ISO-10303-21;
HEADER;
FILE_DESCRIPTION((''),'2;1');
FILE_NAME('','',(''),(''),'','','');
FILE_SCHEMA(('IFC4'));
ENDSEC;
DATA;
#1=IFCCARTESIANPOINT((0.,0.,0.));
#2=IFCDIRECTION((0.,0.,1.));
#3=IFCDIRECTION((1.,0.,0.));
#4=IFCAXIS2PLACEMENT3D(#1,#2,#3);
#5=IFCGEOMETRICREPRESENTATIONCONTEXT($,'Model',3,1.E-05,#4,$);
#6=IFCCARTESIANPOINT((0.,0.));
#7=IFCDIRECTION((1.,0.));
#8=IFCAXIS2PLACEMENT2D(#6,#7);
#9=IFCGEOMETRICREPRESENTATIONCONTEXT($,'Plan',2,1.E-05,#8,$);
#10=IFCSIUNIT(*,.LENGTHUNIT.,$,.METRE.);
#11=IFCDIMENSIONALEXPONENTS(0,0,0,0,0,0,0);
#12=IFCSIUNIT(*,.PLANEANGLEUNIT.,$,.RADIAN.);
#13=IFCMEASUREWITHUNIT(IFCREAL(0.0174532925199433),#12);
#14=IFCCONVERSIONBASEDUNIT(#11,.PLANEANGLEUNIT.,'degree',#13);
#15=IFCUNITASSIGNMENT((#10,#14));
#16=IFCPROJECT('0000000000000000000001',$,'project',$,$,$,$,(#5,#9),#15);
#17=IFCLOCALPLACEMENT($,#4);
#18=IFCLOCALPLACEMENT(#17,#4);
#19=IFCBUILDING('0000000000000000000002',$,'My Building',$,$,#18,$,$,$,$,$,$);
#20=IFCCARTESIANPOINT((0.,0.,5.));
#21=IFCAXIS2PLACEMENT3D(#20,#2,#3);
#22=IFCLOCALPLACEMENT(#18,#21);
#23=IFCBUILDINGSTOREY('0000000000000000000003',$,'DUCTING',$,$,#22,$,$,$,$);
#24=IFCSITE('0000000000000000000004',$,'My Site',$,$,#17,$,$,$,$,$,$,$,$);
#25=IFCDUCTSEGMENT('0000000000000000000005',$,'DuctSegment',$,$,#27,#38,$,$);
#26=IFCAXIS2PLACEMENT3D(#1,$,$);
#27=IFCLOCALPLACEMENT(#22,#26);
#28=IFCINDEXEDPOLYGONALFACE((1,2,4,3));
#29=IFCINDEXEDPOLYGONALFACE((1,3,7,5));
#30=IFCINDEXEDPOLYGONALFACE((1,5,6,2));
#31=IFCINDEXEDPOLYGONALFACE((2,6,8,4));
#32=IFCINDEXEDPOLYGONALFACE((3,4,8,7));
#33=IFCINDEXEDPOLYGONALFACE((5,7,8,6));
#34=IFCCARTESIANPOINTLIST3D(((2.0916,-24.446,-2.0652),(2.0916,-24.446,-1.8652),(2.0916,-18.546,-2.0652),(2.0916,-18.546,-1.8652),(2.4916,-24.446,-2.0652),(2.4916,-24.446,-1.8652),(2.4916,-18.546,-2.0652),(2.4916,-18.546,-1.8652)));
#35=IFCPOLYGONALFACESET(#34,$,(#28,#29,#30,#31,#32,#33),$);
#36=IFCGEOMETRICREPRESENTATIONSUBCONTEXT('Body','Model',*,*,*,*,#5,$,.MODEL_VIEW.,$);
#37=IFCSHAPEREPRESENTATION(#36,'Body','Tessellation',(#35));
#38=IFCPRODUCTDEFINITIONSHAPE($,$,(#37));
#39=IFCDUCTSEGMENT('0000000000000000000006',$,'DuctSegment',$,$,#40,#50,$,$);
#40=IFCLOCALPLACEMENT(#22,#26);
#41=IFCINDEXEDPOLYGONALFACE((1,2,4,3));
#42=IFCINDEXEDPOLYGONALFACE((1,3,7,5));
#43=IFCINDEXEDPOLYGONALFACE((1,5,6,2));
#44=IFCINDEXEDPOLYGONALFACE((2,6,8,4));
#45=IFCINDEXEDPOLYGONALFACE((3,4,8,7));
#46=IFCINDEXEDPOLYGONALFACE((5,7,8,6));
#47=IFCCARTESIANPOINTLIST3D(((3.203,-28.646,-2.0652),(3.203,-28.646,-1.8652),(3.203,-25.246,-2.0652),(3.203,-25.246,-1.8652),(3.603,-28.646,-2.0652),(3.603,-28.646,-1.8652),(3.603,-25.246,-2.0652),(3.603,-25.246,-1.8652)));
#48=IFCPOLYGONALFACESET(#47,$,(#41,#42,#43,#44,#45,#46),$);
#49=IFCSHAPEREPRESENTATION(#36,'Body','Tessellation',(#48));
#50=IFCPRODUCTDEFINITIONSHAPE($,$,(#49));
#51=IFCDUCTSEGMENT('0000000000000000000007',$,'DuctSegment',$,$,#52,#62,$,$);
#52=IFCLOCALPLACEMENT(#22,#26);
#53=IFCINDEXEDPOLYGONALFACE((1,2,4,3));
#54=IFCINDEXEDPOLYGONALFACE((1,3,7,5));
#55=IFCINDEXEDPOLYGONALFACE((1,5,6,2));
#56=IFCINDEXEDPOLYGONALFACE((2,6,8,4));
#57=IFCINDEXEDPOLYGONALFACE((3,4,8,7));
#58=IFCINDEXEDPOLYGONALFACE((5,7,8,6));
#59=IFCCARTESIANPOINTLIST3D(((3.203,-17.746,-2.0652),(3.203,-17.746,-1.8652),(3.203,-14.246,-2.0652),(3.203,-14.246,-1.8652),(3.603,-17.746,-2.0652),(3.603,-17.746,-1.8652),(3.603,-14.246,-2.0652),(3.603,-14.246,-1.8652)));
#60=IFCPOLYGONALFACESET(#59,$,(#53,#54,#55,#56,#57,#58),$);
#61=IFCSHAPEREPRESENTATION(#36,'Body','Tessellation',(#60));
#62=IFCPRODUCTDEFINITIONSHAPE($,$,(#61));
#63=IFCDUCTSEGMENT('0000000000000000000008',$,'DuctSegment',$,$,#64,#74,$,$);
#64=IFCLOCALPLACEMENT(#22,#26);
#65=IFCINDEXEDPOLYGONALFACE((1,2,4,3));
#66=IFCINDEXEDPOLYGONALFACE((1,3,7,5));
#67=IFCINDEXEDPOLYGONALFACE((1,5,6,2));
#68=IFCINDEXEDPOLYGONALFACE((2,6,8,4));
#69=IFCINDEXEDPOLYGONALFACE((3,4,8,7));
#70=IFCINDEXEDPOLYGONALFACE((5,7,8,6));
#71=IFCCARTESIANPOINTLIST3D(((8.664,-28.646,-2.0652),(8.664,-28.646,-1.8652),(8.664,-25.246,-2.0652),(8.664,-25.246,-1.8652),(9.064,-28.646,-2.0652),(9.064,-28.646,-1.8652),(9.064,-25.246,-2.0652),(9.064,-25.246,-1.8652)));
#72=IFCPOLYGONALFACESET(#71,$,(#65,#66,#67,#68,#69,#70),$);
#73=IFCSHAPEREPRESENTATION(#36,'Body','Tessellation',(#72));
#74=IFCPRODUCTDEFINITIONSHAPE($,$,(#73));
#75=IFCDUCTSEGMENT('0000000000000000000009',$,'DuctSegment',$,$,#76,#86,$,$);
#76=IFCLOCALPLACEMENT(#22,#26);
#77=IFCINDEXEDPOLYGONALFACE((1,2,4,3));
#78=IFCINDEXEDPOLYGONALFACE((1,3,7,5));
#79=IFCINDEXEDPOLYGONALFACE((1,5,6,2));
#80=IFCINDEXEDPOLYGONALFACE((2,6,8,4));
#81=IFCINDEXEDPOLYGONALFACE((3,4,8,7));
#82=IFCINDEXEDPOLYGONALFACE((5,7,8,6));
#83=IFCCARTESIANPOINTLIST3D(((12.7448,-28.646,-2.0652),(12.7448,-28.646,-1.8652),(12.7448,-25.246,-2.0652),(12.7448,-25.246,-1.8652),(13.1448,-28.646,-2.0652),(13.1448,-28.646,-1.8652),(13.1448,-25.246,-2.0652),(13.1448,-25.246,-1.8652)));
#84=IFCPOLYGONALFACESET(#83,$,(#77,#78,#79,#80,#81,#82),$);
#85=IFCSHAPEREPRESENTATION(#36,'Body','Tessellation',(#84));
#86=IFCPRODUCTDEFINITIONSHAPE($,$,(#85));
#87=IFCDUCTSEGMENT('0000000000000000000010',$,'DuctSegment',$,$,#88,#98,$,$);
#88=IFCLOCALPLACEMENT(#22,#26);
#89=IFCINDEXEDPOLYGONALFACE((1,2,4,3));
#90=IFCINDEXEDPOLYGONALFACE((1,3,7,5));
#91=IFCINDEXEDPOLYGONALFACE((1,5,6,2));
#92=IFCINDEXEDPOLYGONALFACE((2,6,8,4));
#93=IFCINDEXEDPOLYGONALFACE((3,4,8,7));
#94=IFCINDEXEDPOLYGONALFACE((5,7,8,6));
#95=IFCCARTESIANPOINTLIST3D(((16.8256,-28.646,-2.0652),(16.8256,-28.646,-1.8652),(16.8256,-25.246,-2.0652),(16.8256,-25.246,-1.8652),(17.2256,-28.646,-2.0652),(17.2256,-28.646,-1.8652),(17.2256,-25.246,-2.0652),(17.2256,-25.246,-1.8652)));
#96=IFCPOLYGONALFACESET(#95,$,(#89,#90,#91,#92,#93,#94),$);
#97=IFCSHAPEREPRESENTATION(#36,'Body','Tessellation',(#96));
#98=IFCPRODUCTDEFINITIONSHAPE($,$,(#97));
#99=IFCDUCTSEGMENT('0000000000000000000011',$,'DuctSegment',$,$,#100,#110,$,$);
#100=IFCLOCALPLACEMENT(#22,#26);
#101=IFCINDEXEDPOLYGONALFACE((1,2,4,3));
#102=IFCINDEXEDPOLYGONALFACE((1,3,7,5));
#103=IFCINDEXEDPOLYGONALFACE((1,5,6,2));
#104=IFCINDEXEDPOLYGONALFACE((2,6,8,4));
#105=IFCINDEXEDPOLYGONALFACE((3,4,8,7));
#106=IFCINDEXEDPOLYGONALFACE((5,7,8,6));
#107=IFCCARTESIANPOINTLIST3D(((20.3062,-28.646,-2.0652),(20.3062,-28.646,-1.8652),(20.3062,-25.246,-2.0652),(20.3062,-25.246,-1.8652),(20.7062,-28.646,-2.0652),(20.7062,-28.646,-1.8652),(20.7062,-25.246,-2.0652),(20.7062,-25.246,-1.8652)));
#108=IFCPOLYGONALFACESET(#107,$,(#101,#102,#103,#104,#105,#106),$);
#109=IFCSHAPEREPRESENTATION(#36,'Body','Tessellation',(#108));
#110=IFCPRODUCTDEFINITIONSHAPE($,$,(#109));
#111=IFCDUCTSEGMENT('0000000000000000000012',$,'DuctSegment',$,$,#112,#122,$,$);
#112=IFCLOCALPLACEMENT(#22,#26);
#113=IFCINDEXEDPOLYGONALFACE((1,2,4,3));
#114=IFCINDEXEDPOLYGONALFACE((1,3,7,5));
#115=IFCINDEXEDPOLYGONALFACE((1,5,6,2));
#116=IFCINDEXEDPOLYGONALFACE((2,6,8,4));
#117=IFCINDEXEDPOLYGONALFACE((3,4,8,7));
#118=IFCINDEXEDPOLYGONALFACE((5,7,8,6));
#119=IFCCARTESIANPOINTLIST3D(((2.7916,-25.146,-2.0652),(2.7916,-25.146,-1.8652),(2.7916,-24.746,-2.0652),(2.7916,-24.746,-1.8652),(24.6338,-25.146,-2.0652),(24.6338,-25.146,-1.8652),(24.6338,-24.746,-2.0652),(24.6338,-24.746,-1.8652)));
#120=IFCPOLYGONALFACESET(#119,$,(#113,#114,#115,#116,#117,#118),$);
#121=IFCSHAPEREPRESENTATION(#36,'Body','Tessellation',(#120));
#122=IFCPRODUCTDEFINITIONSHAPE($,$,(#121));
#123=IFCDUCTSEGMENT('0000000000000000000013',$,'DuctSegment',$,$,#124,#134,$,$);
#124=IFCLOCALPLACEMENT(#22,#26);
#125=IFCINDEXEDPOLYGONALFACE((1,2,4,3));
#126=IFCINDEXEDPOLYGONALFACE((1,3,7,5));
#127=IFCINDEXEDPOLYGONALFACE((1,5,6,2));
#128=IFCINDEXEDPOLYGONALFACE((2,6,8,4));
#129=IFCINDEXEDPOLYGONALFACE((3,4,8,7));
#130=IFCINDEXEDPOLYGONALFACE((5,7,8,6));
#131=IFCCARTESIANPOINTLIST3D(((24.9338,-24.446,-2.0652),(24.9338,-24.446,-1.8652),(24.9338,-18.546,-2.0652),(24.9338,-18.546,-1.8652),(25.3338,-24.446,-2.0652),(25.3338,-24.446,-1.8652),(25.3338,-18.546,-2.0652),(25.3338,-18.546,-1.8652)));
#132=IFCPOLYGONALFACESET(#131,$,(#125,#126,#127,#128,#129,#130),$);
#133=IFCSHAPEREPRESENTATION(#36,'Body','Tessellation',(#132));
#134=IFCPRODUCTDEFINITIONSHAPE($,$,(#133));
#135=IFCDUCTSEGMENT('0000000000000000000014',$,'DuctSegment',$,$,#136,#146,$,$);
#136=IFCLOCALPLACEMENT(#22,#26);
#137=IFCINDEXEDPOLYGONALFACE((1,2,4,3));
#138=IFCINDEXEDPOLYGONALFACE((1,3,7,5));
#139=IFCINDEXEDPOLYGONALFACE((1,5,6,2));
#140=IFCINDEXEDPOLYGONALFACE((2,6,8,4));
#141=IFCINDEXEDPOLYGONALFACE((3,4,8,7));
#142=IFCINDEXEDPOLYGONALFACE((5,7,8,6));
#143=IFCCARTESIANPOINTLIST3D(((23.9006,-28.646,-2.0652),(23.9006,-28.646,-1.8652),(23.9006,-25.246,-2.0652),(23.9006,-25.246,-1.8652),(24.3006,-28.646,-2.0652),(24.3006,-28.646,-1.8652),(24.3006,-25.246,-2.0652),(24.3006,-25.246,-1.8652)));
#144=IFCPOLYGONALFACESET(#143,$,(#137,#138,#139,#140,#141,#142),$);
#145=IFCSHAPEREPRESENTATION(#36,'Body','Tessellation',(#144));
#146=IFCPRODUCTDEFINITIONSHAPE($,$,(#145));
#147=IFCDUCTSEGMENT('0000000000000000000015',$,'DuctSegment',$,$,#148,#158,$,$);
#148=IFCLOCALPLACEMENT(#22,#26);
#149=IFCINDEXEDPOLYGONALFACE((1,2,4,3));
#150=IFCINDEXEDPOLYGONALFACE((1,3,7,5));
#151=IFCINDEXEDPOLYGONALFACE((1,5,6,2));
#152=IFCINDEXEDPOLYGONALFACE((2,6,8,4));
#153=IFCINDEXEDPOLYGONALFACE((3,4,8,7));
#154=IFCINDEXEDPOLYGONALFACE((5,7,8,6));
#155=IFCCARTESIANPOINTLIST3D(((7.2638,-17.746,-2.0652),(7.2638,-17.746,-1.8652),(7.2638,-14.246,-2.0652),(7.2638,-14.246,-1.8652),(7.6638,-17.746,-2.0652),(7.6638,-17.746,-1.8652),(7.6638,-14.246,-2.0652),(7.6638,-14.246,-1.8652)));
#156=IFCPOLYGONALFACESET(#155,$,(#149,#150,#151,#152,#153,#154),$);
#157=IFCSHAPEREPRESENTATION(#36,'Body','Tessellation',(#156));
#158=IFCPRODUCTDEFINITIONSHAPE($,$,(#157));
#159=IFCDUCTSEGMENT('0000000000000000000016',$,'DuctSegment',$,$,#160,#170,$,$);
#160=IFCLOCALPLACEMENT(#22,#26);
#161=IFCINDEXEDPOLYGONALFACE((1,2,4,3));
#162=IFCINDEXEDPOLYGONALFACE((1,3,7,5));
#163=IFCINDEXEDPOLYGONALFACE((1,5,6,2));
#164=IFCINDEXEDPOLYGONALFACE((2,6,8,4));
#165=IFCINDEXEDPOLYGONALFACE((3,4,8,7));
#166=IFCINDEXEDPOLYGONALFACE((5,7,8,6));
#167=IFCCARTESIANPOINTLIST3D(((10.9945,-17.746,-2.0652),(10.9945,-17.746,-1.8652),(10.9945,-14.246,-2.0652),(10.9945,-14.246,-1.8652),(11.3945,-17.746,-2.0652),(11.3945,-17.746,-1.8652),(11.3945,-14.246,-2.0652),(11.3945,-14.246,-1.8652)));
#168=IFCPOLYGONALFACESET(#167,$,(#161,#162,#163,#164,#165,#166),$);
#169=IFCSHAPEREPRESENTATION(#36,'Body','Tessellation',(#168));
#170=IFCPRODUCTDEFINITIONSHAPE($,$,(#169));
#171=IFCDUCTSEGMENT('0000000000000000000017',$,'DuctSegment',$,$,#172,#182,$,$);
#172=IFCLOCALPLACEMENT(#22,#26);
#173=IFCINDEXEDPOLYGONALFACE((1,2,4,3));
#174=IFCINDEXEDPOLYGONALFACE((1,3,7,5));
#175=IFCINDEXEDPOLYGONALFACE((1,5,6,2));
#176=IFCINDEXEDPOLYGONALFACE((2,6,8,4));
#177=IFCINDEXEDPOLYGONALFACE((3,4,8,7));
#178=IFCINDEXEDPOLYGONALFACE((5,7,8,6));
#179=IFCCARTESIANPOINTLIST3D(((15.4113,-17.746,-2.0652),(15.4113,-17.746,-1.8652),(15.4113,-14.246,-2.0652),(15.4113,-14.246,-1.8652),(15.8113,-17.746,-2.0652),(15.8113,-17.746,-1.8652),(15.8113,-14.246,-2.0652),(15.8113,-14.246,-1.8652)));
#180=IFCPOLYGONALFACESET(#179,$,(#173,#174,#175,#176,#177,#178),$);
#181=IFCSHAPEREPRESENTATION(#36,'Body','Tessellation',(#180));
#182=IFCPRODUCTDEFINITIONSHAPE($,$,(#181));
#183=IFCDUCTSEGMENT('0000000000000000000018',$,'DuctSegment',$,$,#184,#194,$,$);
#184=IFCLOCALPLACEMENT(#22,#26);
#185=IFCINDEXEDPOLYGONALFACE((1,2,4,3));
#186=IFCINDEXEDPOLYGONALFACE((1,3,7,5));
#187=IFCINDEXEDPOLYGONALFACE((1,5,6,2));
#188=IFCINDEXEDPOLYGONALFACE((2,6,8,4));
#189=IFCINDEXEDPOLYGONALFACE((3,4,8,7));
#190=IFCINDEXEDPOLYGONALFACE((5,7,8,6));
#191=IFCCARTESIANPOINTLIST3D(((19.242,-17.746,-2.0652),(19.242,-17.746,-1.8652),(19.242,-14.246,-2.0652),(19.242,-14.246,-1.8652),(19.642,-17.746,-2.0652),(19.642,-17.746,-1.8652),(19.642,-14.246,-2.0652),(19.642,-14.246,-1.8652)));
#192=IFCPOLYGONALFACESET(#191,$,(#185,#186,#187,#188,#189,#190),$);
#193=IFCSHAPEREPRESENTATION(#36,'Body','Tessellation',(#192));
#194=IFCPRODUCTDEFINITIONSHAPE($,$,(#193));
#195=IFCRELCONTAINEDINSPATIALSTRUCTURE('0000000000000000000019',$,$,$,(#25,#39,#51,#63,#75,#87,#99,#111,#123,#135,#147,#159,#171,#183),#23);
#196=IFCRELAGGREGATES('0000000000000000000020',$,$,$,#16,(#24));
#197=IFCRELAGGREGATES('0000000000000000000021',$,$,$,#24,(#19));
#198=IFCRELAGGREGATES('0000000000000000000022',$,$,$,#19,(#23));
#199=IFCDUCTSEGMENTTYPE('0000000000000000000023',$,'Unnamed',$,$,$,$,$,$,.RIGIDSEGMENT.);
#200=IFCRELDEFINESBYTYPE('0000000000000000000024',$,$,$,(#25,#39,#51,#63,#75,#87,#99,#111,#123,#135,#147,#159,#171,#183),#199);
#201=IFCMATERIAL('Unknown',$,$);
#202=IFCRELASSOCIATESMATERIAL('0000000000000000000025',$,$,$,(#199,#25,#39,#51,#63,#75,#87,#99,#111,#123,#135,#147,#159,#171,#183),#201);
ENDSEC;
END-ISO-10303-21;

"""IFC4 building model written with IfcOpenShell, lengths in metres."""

from ifc_helpers import new_model, entity, si_unit, converted_unit, frame, origin_with_axes, origin_2d_with_axis, place, context, subcontext, project, spatial, rectangle, extrude, material, material_profile, profile_set, profile_usage, type_object, element, save


model = new_model("IFC4")

# Units and contexts
model_context = context("Model", 3, precision=1e-05, world=origin_with_axes())
plan_context = context("Plan", 2, precision=1e-05, world=origin_2d_with_axis())
body_context = subcontext(model_context, "Body", "Model", "MODEL_VIEW")
ifc_project = project(units=[si_unit("LENGTHUNIT", "METRE"), converted_unit("PLANEANGLEUNIT", "degree", entity("IfcReal", 0.0174532925199433), si_unit("PLANEANGLEUNIT", "RADIAN"), dimensions=[0, 0, 0, 0, 0, 0, 0])], contexts=[model_context, plan_context])

# Site, building, storey
site_placement = place(None, origin_with_axes())
site = spatial("IfcSite", under=ifc_project, at=site_placement, Name="My Site")
building_placement = place(site_placement, origin_with_axes())
building = spatial("IfcBuilding", under=site, at=building_placement, Name="My Building")
storey_placement = place(building_placement, frame((0.0, 0.0, 5.0), z_axis=(0.0, 0.0, 1.0), x_axis=(1.0, 0.0, 0.0)))
storey = spatial("IfcBuildingStorey", under=building, at=storey_placement, Name="DUCTING")

# Duct segments
ifc_material = material(Name="Unknown")
ifc_material_profile = material_profile(ifc_material, rectangle(XDim=0.4, YDim=0.2))
ifc_profile_set = profile_set([ifc_material_profile])
ifc_profile_usage_1 = profile_usage(ifc_profile_set, cardinal=5)
duct_segment_type = type_object("IfcDuctSegmentType", Name="Unnamed", PredefinedType="RIGIDSEGMENT", material=ifc_profile_set)
duct_segment_1_placement = place(storey_placement, frame((2.2916, -18.546, -1.9652), z_axis=(0.0, -1.0, -0.000002), x_axis=(1.0, 0.0, 0.0)))
element("IfcDuctSegment", 1, at=duct_segment_1_placement, inside=storey, type_object=duct_segment_type, material=ifc_profile_usage_1, Name="DuctSegment", context=body_context, shape_type="SweptSolid", body=[
    extrude(rectangle(XDim=0.4, YDim=0.2), origin_with_axes(), (0.0, 0.0, 1.0), 5.9),
])
ifc_profile_usage_2 = profile_usage(ifc_profile_set, cardinal=5)
duct_segment_2_placement = place(storey_placement, frame((3.403, -25.246, -1.9652), z_axis=(0.0, -1.0, 0.000001), x_axis=(1.0, 0.0, 0.0)))
element("IfcDuctSegment", 2, at=duct_segment_2_placement, inside=storey, type_object=duct_segment_type, material=ifc_profile_usage_2, Name="DuctSegment", context=body_context, shape_type="SweptSolid", body=[
    extrude(rectangle(XDim=0.4, YDim=0.2), origin_with_axes(), (0.0, 0.0, 1.0), 3.4),
])
ifc_profile_usage_3 = profile_usage(ifc_profile_set, cardinal=5)
duct_segment_3_placement = place(storey_placement, frame((3.403, -14.246, -1.9652), z_axis=(0.0, -1.0, 0.000001), x_axis=(1.0, 0.0, 0.0)))
element("IfcDuctSegment", 3, at=duct_segment_3_placement, inside=storey, type_object=duct_segment_type, material=ifc_profile_usage_3, Name="DuctSegment", context=body_context, shape_type="SweptSolid", body=[
    extrude(rectangle(XDim=0.4, YDim=0.2), origin_with_axes(), (0.0, 0.0, 1.0), 3.5),
])
ifc_profile_usage_4 = profile_usage(ifc_profile_set, cardinal=5)
duct_segment_4_placement = place(storey_placement, frame((8.864, -25.246, -1.9652), z_axis=(0.0, -1.0, 0.000001), x_axis=(1.0, 0.0, 0.0)))
element("IfcDuctSegment", 4, at=duct_segment_4_placement, inside=storey, type_object=duct_segment_type, material=ifc_profile_usage_4, Name="DuctSegment", context=body_context, shape_type="SweptSolid", body=[
    extrude(rectangle(XDim=0.4, YDim=0.2), origin_with_axes(), (0.0, 0.0, 1.0), 3.4),
])
ifc_profile_usage_5 = profile_usage(ifc_profile_set, cardinal=5)
duct_segment_5_placement = place(storey_placement, frame((12.9448, -25.246, -1.9652), z_axis=(0.0, -1.0, 0.000001), x_axis=(1.0, 0.0, 0.0)))
element("IfcDuctSegment", 5, at=duct_segment_5_placement, inside=storey, type_object=duct_segment_type, material=ifc_profile_usage_5, Name="DuctSegment", context=body_context, shape_type="SweptSolid", body=[
    extrude(rectangle(XDim=0.4, YDim=0.2), origin_with_axes(), (0.0, 0.0, 1.0), 3.4),
])
ifc_profile_usage_6 = profile_usage(ifc_profile_set, cardinal=5)
duct_segment_6_placement = place(storey_placement, frame((17.0256, -25.246, -1.9652), z_axis=(0.0, -1.0, 0.000001), x_axis=(1.0, 0.0, 0.0)))
element("IfcDuctSegment", 6, at=duct_segment_6_placement, inside=storey, type_object=duct_segment_type, material=ifc_profile_usage_6, Name="DuctSegment", context=body_context, shape_type="SweptSolid", body=[
    extrude(rectangle(XDim=0.4, YDim=0.2), origin_with_axes(), (0.0, 0.0, 1.0), 3.4),
])
ifc_profile_usage_7 = profile_usage(ifc_profile_set, cardinal=5)
duct_segment_7_placement = place(storey_placement, frame((20.5062, -25.246, -1.9652), z_axis=(0.0, -1.0, 0.000001), x_axis=(1.0, 0.0, 0.0)))
element("IfcDuctSegment", 7, at=duct_segment_7_placement, inside=storey, type_object=duct_segment_type, material=ifc_profile_usage_7, Name="DuctSegment", context=body_context, shape_type="SweptSolid", body=[
    extrude(rectangle(XDim=0.4, YDim=0.2), origin_with_axes(), (0.0, 0.0, 1.0), 3.4),
])
ifc_profile_usage_8 = profile_usage(ifc_profile_set, cardinal=5)
duct_segment_8_placement = place(storey_placement, frame((2.7916, -24.946, -1.9652), z_axis=(1.0, 0.0, 0.000001), x_axis=(0.0, 1.0, 0.0)))
element("IfcDuctSegment", 8, at=duct_segment_8_placement, inside=storey, type_object=duct_segment_type, material=ifc_profile_usage_8, Name="DuctSegment", context=body_context, shape_type="SweptSolid", body=[
    extrude(rectangle(XDim=0.4, YDim=0.2), origin_with_axes(), (0.0, 0.0, 1.0), 21.8422),
])
ifc_profile_usage_9 = profile_usage(ifc_profile_set, cardinal=5)
duct_segment_9_placement = place(storey_placement, frame((25.1338, -18.546, -1.9652), z_axis=(0.0, -1.0, 0.0), x_axis=(1.0, 0.0, 0.0)))
element("IfcDuctSegment", 9, at=duct_segment_9_placement, inside=storey, type_object=duct_segment_type, material=ifc_profile_usage_9, Name="DuctSegment", context=body_context, shape_type="SweptSolid", body=[
    extrude(rectangle(XDim=0.4, YDim=0.2), origin_with_axes(), (0.0, 0.0, 1.0), 5.9),
])
ifc_profile_usage_10 = profile_usage(ifc_profile_set, cardinal=5)
duct_segment_10_placement = place(storey_placement, frame((24.1006, -25.246, -1.9652), z_axis=(0.0, -1.0, 0.000001), x_axis=(1.0, 0.0, 0.0)))
element("IfcDuctSegment", 10, at=duct_segment_10_placement, inside=storey, type_object=duct_segment_type, material=ifc_profile_usage_10, Name="DuctSegment", context=body_context, shape_type="SweptSolid", body=[
    extrude(rectangle(XDim=0.4, YDim=0.2), origin_with_axes(), (0.0, 0.0, 1.0), 3.4),
])
ifc_profile_usage_11 = profile_usage(ifc_profile_set, cardinal=5)
duct_segment_11_placement = place(storey_placement, frame((7.4638, -14.246, -1.9652), z_axis=(0.0, -1.0, 0.000001), x_axis=(1.0, 0.0, 0.0)))
element("IfcDuctSegment", 11, at=duct_segment_11_placement, inside=storey, type_object=duct_segment_type, material=ifc_profile_usage_11, Name="DuctSegment", context=body_context, shape_type="SweptSolid", body=[
    extrude(rectangle(XDim=0.4, YDim=0.2), origin_with_axes(), (0.0, 0.0, 1.0), 3.5),
])
ifc_profile_usage_12 = profile_usage(ifc_profile_set, cardinal=5)
duct_segment_12_placement = place(storey_placement, frame((11.1945, -14.246, -1.9652), z_axis=(0.0, -1.0, 0.000001), x_axis=(1.0, 0.0, 0.0)))
element("IfcDuctSegment", 12, at=duct_segment_12_placement, inside=storey, type_object=duct_segment_type, material=ifc_profile_usage_12, Name="DuctSegment", context=body_context, shape_type="SweptSolid", body=[
    extrude(rectangle(XDim=0.4, YDim=0.2), origin_with_axes(), (0.0, 0.0, 1.0), 3.5),
])
ifc_profile_usage_13 = profile_usage(ifc_profile_set, cardinal=5)
duct_segment_13_placement = place(storey_placement, frame((15.6113, -14.246, -1.9652), z_axis=(0.0, -1.0, 0.000001), x_axis=(1.0, 0.0, 0.0)))
element("IfcDuctSegment", 13, at=duct_segment_13_placement, inside=storey, type_object=duct_segment_type, material=ifc_profile_usage_13, Name="DuctSegment", context=body_context, shape_type="SweptSolid", body=[
    extrude(rectangle(XDim=0.4, YDim=0.2), origin_with_axes(), (0.0, 0.0, 1.0), 3.5),
])
ifc_profile_usage_14 = profile_usage(ifc_profile_set, cardinal=5)
duct_segment_14_placement = place(storey_placement, frame((19.442, -14.246, -1.9652), z_axis=(0.0, -1.0, 0.000001), x_axis=(1.0, 0.0, 0.0)))
element("IfcDuctSegment", 14, at=duct_segment_14_placement, inside=storey, type_object=duct_segment_type, material=ifc_profile_usage_14, Name="DuctSegment", context=body_context, shape_type="SweptSolid", body=[
    extrude(rectangle(XDim=0.4, YDim=0.2), origin_with_axes(), (0.0, 0.0, 1.0), 3.5),
])

save(model, "model.ifc")
